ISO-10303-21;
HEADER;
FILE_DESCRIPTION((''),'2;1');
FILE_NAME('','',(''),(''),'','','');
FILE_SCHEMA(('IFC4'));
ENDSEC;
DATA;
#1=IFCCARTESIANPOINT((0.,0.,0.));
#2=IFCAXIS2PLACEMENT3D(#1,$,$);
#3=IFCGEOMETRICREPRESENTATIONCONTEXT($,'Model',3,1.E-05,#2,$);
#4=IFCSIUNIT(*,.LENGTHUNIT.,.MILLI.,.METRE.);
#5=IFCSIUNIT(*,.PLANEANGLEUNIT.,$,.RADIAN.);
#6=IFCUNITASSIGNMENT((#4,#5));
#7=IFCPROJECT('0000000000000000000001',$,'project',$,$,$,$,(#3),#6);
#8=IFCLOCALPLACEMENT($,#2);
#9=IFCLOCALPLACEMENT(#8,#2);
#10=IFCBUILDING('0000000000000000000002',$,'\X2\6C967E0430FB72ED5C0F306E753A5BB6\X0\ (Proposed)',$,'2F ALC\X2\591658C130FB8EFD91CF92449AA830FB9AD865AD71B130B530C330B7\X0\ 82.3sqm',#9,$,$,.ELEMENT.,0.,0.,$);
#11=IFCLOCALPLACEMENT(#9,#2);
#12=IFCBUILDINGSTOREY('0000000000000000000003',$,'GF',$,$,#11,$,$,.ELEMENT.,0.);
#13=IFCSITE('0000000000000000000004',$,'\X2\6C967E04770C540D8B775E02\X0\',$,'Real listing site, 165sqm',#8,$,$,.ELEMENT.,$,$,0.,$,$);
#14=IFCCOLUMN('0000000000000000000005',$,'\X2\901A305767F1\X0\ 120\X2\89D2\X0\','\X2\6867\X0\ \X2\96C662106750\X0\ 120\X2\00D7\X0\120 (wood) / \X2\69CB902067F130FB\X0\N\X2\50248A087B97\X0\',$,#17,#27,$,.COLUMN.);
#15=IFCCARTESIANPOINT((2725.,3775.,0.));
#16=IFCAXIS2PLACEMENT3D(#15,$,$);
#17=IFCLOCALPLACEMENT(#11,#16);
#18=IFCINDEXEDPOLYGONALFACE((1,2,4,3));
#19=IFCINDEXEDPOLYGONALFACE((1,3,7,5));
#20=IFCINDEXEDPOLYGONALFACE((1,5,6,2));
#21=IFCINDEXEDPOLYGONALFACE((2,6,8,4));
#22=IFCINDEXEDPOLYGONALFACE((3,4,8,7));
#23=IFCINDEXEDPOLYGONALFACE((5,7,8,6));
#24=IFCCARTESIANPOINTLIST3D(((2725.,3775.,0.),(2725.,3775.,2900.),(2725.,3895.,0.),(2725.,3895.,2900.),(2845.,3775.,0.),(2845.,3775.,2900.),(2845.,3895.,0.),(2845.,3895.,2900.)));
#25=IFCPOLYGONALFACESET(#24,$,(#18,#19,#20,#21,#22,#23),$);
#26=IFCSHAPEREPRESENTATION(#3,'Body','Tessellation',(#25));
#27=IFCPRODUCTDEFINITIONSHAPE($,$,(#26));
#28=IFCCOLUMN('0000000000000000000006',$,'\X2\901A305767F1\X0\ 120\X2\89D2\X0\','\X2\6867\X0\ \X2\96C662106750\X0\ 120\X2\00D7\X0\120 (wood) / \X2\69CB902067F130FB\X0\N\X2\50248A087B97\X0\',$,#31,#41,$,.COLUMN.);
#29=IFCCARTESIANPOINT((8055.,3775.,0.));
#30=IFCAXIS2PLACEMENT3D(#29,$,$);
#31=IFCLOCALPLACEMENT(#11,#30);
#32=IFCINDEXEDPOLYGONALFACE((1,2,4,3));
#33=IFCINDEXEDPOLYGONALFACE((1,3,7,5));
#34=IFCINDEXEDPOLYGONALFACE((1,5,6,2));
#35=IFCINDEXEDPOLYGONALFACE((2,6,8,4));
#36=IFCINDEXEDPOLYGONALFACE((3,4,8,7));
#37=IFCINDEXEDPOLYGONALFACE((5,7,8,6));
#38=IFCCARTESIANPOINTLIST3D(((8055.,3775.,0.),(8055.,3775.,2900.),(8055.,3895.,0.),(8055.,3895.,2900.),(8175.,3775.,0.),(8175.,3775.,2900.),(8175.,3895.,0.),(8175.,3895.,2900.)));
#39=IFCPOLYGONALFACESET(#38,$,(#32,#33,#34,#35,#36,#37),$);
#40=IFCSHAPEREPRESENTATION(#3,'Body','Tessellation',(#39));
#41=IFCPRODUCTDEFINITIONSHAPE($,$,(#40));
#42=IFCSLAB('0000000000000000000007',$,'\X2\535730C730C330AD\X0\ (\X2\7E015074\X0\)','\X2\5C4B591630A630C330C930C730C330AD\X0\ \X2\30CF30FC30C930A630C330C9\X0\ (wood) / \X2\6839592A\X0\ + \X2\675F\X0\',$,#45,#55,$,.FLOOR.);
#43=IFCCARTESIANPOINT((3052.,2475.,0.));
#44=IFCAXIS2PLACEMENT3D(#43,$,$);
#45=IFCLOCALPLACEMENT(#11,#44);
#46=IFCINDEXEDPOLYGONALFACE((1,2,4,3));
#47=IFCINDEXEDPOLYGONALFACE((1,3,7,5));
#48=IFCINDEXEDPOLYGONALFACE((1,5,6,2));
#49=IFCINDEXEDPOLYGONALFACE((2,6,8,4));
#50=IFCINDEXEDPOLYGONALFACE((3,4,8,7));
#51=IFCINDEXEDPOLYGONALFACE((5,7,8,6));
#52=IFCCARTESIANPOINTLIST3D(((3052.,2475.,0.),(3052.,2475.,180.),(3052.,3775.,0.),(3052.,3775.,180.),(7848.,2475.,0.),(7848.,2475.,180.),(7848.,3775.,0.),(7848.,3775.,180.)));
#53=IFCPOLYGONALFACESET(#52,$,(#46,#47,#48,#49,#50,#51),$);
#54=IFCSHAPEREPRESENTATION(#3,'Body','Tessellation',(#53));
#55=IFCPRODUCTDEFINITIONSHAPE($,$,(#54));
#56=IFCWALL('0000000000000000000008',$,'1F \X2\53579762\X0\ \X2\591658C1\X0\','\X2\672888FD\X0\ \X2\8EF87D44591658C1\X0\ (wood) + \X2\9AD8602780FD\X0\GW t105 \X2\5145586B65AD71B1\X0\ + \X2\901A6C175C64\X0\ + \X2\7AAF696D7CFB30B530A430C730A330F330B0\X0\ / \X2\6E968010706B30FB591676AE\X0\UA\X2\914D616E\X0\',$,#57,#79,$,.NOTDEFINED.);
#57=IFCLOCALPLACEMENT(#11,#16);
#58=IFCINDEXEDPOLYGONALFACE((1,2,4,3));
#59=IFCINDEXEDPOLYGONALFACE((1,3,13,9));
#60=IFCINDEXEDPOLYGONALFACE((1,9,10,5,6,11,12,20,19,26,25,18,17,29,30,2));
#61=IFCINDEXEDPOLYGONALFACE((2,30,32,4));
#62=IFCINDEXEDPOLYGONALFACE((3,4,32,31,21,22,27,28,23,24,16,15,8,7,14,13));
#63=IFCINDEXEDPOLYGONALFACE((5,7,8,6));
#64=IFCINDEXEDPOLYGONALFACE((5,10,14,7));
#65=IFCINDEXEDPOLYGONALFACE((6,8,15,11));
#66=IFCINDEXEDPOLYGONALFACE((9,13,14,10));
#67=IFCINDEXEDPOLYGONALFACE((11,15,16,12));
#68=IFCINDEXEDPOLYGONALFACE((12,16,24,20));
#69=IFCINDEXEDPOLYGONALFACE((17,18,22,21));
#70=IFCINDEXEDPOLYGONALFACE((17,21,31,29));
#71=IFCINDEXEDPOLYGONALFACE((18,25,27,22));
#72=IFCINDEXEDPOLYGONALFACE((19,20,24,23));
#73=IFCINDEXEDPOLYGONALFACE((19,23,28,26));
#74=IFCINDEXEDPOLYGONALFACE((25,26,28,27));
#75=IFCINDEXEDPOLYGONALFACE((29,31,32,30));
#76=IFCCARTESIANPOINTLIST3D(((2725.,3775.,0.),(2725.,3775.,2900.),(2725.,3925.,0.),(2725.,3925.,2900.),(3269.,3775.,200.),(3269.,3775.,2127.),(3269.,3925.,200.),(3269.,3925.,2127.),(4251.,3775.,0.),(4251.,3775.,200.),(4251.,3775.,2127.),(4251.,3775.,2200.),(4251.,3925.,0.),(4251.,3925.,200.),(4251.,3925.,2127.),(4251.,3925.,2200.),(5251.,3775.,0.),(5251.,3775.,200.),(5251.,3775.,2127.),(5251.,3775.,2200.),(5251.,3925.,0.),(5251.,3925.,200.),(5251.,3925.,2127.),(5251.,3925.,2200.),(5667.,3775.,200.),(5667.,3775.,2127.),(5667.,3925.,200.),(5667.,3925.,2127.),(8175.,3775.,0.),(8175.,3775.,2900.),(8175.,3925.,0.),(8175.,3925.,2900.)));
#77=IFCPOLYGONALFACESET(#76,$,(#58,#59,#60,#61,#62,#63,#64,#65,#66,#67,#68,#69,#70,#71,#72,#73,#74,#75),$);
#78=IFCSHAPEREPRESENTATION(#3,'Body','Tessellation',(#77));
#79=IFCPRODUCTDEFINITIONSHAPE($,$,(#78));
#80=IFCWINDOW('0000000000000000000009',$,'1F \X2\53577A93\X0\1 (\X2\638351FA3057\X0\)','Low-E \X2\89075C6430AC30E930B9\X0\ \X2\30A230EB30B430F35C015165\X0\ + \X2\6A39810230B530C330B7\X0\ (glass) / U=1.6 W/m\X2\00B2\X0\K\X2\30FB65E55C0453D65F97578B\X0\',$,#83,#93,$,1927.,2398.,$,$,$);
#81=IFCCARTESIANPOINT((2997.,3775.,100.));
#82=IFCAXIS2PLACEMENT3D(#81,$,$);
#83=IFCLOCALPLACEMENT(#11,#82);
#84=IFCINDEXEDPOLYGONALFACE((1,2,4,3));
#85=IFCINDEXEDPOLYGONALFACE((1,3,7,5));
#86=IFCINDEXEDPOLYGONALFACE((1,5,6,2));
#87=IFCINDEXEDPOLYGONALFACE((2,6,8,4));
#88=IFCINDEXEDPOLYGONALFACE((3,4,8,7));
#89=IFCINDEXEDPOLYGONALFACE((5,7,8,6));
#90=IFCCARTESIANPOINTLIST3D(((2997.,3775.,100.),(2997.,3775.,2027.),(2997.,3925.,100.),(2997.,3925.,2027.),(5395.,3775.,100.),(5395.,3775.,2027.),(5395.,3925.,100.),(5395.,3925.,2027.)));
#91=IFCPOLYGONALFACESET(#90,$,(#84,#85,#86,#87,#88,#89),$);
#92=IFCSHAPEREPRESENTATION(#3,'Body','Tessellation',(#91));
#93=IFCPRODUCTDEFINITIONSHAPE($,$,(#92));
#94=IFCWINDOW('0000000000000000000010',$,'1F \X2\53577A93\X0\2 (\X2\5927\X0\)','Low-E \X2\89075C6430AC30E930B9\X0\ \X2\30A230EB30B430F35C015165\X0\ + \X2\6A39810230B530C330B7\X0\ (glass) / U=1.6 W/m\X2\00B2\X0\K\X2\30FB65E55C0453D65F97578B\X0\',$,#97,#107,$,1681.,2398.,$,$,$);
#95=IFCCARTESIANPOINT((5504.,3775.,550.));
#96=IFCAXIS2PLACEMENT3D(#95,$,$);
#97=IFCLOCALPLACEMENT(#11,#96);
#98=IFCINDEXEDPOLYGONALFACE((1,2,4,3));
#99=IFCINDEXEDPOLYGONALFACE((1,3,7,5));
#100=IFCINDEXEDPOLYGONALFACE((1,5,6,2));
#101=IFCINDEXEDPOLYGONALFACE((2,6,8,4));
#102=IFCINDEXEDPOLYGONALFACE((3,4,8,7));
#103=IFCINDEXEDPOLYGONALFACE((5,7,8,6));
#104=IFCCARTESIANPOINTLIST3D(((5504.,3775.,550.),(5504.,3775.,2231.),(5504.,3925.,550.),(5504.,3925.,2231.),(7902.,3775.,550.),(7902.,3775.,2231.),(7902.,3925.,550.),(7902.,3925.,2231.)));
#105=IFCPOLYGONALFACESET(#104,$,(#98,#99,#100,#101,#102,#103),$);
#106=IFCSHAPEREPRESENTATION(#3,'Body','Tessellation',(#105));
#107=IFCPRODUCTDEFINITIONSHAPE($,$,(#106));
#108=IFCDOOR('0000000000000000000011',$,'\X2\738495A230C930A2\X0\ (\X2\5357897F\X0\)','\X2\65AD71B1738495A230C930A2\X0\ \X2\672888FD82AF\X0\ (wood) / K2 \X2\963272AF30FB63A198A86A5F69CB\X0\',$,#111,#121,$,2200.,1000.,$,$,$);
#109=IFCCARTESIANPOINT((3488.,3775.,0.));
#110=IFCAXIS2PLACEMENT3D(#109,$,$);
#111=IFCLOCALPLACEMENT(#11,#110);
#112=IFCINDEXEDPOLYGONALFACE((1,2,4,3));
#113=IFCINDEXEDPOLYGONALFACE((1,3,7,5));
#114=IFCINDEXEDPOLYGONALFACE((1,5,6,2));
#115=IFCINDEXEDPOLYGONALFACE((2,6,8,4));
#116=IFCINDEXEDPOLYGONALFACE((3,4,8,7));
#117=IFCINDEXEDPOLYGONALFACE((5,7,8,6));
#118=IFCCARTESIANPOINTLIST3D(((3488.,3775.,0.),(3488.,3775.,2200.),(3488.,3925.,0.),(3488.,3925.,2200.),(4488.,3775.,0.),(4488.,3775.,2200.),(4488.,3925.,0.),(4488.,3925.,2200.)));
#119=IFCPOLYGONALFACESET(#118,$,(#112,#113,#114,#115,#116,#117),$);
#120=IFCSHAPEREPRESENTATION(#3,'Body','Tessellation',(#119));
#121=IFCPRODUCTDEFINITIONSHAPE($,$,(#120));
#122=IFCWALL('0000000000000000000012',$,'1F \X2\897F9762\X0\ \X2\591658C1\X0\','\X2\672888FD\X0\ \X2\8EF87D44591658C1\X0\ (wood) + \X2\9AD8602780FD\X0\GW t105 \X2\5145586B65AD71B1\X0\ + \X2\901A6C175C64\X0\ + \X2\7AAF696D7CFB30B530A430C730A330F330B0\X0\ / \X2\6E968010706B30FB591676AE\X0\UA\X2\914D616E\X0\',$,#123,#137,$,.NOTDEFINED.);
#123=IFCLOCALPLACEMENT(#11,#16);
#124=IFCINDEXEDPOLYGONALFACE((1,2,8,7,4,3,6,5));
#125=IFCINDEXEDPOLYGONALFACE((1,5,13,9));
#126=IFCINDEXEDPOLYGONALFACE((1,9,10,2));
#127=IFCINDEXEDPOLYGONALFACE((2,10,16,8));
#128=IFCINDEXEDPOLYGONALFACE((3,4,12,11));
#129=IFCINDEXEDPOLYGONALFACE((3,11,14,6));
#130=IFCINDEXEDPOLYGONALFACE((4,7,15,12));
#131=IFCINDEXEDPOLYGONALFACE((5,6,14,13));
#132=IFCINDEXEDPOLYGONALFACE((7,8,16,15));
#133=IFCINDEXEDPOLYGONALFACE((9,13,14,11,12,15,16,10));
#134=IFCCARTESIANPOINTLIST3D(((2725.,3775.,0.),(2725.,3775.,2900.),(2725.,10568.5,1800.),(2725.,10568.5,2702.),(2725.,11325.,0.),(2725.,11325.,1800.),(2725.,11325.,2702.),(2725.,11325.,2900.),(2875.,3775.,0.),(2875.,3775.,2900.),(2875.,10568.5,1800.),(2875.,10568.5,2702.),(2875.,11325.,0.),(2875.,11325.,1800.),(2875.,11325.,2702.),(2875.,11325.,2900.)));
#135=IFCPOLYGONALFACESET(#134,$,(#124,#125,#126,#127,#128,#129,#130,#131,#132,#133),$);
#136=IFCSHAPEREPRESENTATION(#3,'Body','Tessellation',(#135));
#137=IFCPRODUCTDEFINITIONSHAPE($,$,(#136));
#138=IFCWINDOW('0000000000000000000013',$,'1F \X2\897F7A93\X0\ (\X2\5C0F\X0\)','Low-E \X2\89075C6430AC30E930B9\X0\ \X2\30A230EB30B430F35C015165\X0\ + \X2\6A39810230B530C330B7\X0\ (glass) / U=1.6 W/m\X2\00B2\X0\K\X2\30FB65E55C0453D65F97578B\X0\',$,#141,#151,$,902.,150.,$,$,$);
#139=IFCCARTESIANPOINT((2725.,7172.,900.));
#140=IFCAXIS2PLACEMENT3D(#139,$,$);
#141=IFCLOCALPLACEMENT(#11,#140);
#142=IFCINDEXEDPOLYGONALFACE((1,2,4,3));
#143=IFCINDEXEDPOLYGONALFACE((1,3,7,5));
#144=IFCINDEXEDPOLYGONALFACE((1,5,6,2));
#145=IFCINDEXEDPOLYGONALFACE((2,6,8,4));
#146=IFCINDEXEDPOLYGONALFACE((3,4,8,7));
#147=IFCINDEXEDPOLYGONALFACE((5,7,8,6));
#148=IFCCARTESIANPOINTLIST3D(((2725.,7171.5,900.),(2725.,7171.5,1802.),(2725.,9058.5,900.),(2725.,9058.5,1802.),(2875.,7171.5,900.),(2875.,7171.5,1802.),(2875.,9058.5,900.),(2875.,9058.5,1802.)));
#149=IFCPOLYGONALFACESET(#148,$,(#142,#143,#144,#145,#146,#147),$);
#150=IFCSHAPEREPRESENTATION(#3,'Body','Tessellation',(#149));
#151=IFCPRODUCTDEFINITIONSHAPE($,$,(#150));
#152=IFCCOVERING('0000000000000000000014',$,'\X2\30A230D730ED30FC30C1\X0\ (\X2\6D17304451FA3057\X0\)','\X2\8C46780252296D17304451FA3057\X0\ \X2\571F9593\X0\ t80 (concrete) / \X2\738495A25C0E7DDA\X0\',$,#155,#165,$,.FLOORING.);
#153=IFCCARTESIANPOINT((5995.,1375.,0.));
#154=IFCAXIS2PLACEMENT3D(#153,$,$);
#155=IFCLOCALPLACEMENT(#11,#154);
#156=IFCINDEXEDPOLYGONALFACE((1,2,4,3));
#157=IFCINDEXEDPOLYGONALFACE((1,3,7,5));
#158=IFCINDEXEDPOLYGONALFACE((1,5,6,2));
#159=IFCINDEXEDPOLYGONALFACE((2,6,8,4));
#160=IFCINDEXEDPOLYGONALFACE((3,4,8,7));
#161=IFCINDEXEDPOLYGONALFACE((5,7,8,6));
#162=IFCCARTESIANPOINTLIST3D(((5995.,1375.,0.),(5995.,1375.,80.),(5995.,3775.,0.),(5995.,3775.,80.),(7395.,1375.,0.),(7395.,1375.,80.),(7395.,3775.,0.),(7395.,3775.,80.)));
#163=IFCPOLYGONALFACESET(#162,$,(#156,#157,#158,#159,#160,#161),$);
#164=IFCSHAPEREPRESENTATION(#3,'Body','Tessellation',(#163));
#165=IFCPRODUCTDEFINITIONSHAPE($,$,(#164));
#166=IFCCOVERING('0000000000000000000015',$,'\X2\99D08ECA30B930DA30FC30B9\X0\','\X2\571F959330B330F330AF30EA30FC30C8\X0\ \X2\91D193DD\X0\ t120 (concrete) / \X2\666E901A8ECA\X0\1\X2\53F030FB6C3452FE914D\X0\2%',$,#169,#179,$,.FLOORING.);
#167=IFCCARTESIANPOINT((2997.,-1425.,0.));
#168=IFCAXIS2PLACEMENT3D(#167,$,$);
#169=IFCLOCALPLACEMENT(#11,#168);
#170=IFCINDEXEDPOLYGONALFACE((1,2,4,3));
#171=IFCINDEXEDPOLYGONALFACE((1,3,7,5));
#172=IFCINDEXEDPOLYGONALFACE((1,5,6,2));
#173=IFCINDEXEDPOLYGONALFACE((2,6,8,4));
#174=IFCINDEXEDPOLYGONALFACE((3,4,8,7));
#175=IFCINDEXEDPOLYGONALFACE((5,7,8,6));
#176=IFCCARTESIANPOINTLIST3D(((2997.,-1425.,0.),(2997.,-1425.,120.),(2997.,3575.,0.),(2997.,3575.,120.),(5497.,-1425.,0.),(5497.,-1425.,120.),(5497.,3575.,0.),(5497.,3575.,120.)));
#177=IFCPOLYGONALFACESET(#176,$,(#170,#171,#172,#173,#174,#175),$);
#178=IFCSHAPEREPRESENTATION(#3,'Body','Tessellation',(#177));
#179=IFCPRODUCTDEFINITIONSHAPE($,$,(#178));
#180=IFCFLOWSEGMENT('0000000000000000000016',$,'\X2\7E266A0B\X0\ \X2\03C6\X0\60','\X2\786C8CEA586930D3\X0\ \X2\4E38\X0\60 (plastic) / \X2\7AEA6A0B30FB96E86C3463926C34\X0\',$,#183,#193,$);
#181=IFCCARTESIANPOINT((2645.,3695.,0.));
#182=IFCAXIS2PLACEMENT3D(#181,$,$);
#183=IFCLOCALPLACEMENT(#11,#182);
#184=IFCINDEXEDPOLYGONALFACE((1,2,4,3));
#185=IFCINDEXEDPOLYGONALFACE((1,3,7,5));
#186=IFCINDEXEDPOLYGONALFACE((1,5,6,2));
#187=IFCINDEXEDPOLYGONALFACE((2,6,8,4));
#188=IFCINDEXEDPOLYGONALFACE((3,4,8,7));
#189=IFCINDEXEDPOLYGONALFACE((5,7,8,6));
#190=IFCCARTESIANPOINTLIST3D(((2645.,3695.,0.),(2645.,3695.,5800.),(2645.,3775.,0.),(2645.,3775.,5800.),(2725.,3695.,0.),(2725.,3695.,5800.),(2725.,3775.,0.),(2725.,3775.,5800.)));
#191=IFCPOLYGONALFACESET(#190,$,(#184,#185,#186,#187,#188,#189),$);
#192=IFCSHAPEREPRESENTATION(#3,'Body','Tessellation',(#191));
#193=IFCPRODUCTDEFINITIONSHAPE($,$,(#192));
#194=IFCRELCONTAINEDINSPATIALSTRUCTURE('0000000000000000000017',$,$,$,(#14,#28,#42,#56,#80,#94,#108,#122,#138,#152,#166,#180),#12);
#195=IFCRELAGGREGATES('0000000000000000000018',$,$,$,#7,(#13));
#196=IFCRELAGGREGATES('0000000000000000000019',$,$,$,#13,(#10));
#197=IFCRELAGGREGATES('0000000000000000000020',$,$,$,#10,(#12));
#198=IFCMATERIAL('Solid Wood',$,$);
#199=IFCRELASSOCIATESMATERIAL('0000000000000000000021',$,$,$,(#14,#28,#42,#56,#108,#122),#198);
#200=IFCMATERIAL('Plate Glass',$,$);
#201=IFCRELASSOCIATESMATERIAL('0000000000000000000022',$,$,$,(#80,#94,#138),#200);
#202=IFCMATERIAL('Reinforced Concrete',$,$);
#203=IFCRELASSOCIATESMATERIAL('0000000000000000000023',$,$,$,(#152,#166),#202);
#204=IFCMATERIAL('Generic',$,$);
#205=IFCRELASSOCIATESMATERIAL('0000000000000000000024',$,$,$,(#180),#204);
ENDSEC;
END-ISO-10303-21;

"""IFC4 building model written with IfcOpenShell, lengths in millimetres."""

from ifc_helpers import new_model, si_unit, frame, frame_2d, origin, place, context, project, spatial, rectangle, extrude, material, element, fill, save


model = new_model("IFC4")

# Units and contexts
model_context = context("Model", 3, precision=1e-05, world=origin())
ifc_project = project(units=[si_unit("LENGTHUNIT", "METRE", prefix="MILLI"), si_unit("PLANEANGLEUNIT", "RADIAN")], contexts=[model_context])

# Site, building, storey
site_placement = place(None, origin())
site = spatial("IfcSite", under=ifc_project, at=site_placement, Name="沖縄県名護市", ObjectType="Real listing site, 165sqm", CompositionType="ELEMENT", RefElevation=0.0)
building_placement = place(site_placement, origin())
building = spatial("IfcBuilding", under=site, at=building_placement, Name="沖縄・狭小の町家 (Proposed)", ObjectType="2F ALC外壁・軽量鉄骨・高断熱サッシ 82.3sqm", CompositionType="ELEMENT", ElevationOfRefHeight=0.0, ElevationOfTerrain=0.0)
storey_placement = place(building_placement, origin())
storey = spatial("IfcBuildingStorey", under=building, at=storey_placement, Name="GF", CompositionType="ELEMENT", Elevation=0.0)

# Columns
ifc_material_1 = material(Name="Solid Wood")
column_1_placement = place(storey_placement, frame((2725.0, 3775.0, 0.0)))
element("IfcColumn", 1, at=column_1_placement, inside=storey, material=ifc_material_1, Name="通し柱 120角", Description="桧 集成材 120×120 (wood) / 構造柱・N値計算", PredefinedType="COLUMN", context=model_context, shape_type="SweptSolid", body=[
    extrude(rectangle(XDim=120.0, YDim=120.0, at=frame_2d((60.0, 60.0))), frame((2725.0, 3775.0, 0.0)), (0.0, 0.0, 1.0), 2900.0),
])
column_2_placement = place(storey_placement, frame((8055.0, 3775.0, 0.0)))
element("IfcColumn", 2, at=column_2_placement, inside=storey, material=ifc_material_1, Name="通し柱 120角", Description="桧 集成材 120×120 (wood) / 構造柱・N値計算", PredefinedType="COLUMN", context=model_context, shape_type="SweptSolid", body=[
    extrude(rectangle(XDim=120.0, YDim=120.0, at=frame_2d((60.0, 60.0))), frame((8055.0, 3775.0, 0.0)), (0.0, 0.0, 1.0), 2900.0),
])

# Slab
ifc_material_2 = material(Name="Reinforced Concrete")
slab_1_placement = place(storey_placement, frame((3052.0, 2475.0, 0.0)))
element("IfcSlab", 3, at=slab_1_placement, inside=storey, material=ifc_material_1, Name="南デッキ (縁側)", Description="屋外ウッドデッキ ハードウッド (wood) / 根太 + 束", PredefinedType="FLOOR", context=model_context, shape_type="SweptSolid", body=[
    extrude(rectangle(XDim=4796.0, YDim=1300.0, at=frame_2d((2398.0, 650.0))), frame((3052.0, 2475.0, 0.0)), (0.0, 0.0, 1.0), 180.0),
])

# Wall, openings, windows, door
wall_1_placement = place(storey_placement, frame((2725.0, 3775.0, 0.0)))
wall_1 = element("IfcWall", 4, at=wall_1_placement, inside=storey, material=ifc_material_1, Name="1F 南面 外壁", Description="木製 軸組外壁 (wood) + 高性能GW t105 充填断熱 + 通気層 + 窯業系サイディング / 準耐火・外皮UA配慮", PredefinedType="NOTDEFINED", context=model_context, shape_type="SweptSolid", body=[
    extrude(rectangle(XDim=5450.0, YDim=150.0, at=frame_2d((2725.0, 75.0))), frame((2725.0, 3775.0, 0.0)), (0.0, 0.0, 1.0), 2900.0),
])
opening_1_placement = place(storey_placement, frame((2997.0, 3775.0, 100.0)))
opening_1 = element("IfcOpeningElement", 5, at=opening_1_placement, cuts=wall_1, PredefinedType="NOTDEFINED", context=model_context, shape_type="SweptSolid", body=[
    extrude(rectangle(XDim=2398.0, YDim=150.0, at=frame_2d((1199.0, 75.0))), frame((2997.0, 3775.0, 100.0)), (0.0, 0.0, 1.0), 1927.0),
])
opening_2_placement = place(storey_placement, frame((5504.0, 3775.0, 550.0)))
opening_2 = element("IfcOpeningElement", 6, at=opening_2_placement, cuts=wall_1, PredefinedType="NOTDEFINED", context=model_context, shape_type="SweptSolid", body=[
    extrude(rectangle(XDim=2398.0, YDim=150.0, at=frame_2d((1199.0, 75.0))), frame((5504.0, 3775.0, 550.0)), (0.0, 0.0, 1.0), 1681.0),
])
opening_3_placement = place(storey_placement, frame((3488.0, 3775.0, 0.0)))
opening_3 = element("IfcOpeningElement", 7, at=opening_3_placement, cuts=wall_1, PredefinedType="NOTDEFINED", context=model_context, shape_type="SweptSolid", body=[
    extrude(rectangle(XDim=1000.0, YDim=150.0, at=frame_2d((500.0, 75.0))), frame((3488.0, 3775.0, 0.0)), (0.0, 0.0, 1.0), 2200.0),
])
ifc_material_3 = material(Name="Plate Glass")
window_1_placement = place(storey_placement, frame((2997.0, 3775.0, 100.0)))
window_1 = element("IfcWindow", 8, at=window_1_placement, inside=storey, material=ifc_material_3, Name="1F 南窓1 (掃出し)", Description="Low-E 複層ガラス アルゴン封入 + 樹脂サッシ (glass) / U=1.6 W/m²K・日射取得型", OverallHeight=1927.0, OverallWidth=2398.0, context=model_context, shape_type="SweptSolid", body=[
    extrude(rectangle(XDim=2398.0, YDim=150.0, at=frame_2d((1199.0, 75.0))), frame((2997.0, 3775.0, 100.0)), (0.0, 0.0, 1.0), 1927.0),
])
fill(opening_1, window_1)
window_2_placement = place(storey_placement, frame((5504.0, 3775.0, 550.0)))
window_2 = element("IfcWindow", 9, at=window_2_placement, inside=storey, material=ifc_material_3, Name="1F 南窓2 (大)", Description="Low-E 複層ガラス アルゴン封入 + 樹脂サッシ (glass) / U=1.6 W/m²K・日射取得型", OverallHeight=1681.0, OverallWidth=2398.0, context=model_context, shape_type="SweptSolid", body=[
    extrude(rectangle(XDim=2398.0, YDim=150.0, at=frame_2d((1199.0, 75.0))), frame((5504.0, 3775.0, 550.0)), (0.0, 0.0, 1.0), 1681.0),
])
fill(opening_2, window_2)
door_placement = place(storey_placement, frame((3488.0, 3775.0, 0.0)))
door = element("IfcDoor", 10, at=door_placement, inside=storey, material=ifc_material_1, Name="玄関ドア (南西)", Description="断熱玄関ドア 木製芯 (wood) / K2 防犯・採風機構", OverallHeight=2200.0, OverallWidth=1000.0, context=model_context, shape_type="SweptSolid", body=[
    extrude(rectangle(XDim=1000.0, YDim=150.0, at=frame_2d((500.0, 75.0))), frame((3488.0, 3775.0, 0.0)), (0.0, 0.0, 1.0), 2200.0),
])
fill(opening_3, door)

# Wall, opening, window
wall_2_placement = place(storey_placement, frame((2725.0, 3775.0, 0.0)))
wall_2 = element("IfcWall", 11, at=wall_2_placement, inside=storey, material=ifc_material_1, Name="1F 西面 外壁", Description="木製 軸組外壁 (wood) + 高性能GW t105 充填断熱 + 通気層 + 窯業系サイディング / 準耐火・外皮UA配慮", PredefinedType="NOTDEFINED", context=model_context, shape_type="SweptSolid", body=[
    extrude(rectangle(XDim=150.0, YDim=7550.0, at=frame_2d((75.0, 3775.0))), frame((2725.0, 3775.0, 0.0)), (0.0, 0.0, 1.0), 2900.0),
])
opening_4_placement = place(storey_placement, frame((2725.0, 7172.0, 900.0)))
opening_4 = element("IfcOpeningElement", 12, at=opening_4_placement, cuts=wall_2, PredefinedType="NOTDEFINED", context=model_context, shape_type="SweptSolid", body=[
    extrude(rectangle(XDim=150.0, YDim=1887.0, at=frame_2d((75.0, 943.0))), frame((2725.0, 7172.0, 900.0)), (0.0, 0.0, 1.0), 902.0),
])
window_3_placement = place(storey_placement, frame((2725.0, 7172.0, 900.0)))
window_3 = element("IfcWindow", 13, at=window_3_placement, inside=storey, material=ifc_material_3, Name="1F 西窓 (小)", Description="Low-E 複層ガラス アルゴン封入 + 樹脂サッシ (glass) / U=1.6 W/m²K・日射取得型", OverallHeight=902.0, OverallWidth=150.0, context=model_context, shape_type="SweptSolid", body=[
    extrude(rectangle(XDim=150.0, YDim=1887.0, at=frame_2d((75.0, 943.0))), frame((2725.0, 7172.0, 900.0)), (0.0, 0.0, 1.0), 902.0),
])
fill(opening_4, window_3)

# Coverings
covering_1_placement = place(storey_placement, frame((5995.0, 1375.0, 0.0)))
element("IfcCovering", 14, at=covering_1_placement, inside=storey, material=ifc_material_2, Name="アプローチ (洗い出し)", Description="豆砂利洗い出し 土間 t80 (concrete) / 玄関導線", PredefinedType="FLOORING", context=model_context, shape_type="SweptSolid", body=[
    extrude(rectangle(XDim=1400.0, YDim=2400.0, at=frame_2d((700.0, 1200.0))), frame((5995.0, 1375.0, 0.0)), (0.0, 0.0, 1.0), 80.0),
])
covering_2_placement = place(storey_placement, frame((2997.0, -1425.0, 0.0)))
element("IfcCovering", 15, at=covering_2_placement, inside=storey, material=ifc_material_2, Name="駐車スペース", Description="土間コンクリート 金鏝 t120 (concrete) / 普通車1台・水勾配2%", PredefinedType="FLOORING", context=model_context, shape_type="SweptSolid", body=[
    extrude(rectangle(XDim=2500.0, YDim=5000.0, at=frame_2d((1250.0, 2500.0))), frame((2997.0, -1425.0, 0.0)), (0.0, 0.0, 1.0), 120.0),
])

# Flow segment
ifc_material_4 = material(Name="Generic")
flow_segment_1_placement = place(storey_placement, frame((2645.0, 3695.0, 0.0)))
element("IfcFlowSegment", 16, at=flow_segment_1_placement, inside=storey, material=ifc_material_4, Name="縦樋 φ60", Description="硬質塩ビ 丸60 (plastic) / 竪樋・雨水排水", context=model_context, shape_type="SweptSolid", body=[
    extrude(rectangle(XDim=80.0, YDim=80.0, at=frame_2d((40.0, 40.0))), frame((2645.0, 3695.0, 0.0)), (0.0, 0.0, 1.0), 5800.0),
])

save(model, "model.ifc")
